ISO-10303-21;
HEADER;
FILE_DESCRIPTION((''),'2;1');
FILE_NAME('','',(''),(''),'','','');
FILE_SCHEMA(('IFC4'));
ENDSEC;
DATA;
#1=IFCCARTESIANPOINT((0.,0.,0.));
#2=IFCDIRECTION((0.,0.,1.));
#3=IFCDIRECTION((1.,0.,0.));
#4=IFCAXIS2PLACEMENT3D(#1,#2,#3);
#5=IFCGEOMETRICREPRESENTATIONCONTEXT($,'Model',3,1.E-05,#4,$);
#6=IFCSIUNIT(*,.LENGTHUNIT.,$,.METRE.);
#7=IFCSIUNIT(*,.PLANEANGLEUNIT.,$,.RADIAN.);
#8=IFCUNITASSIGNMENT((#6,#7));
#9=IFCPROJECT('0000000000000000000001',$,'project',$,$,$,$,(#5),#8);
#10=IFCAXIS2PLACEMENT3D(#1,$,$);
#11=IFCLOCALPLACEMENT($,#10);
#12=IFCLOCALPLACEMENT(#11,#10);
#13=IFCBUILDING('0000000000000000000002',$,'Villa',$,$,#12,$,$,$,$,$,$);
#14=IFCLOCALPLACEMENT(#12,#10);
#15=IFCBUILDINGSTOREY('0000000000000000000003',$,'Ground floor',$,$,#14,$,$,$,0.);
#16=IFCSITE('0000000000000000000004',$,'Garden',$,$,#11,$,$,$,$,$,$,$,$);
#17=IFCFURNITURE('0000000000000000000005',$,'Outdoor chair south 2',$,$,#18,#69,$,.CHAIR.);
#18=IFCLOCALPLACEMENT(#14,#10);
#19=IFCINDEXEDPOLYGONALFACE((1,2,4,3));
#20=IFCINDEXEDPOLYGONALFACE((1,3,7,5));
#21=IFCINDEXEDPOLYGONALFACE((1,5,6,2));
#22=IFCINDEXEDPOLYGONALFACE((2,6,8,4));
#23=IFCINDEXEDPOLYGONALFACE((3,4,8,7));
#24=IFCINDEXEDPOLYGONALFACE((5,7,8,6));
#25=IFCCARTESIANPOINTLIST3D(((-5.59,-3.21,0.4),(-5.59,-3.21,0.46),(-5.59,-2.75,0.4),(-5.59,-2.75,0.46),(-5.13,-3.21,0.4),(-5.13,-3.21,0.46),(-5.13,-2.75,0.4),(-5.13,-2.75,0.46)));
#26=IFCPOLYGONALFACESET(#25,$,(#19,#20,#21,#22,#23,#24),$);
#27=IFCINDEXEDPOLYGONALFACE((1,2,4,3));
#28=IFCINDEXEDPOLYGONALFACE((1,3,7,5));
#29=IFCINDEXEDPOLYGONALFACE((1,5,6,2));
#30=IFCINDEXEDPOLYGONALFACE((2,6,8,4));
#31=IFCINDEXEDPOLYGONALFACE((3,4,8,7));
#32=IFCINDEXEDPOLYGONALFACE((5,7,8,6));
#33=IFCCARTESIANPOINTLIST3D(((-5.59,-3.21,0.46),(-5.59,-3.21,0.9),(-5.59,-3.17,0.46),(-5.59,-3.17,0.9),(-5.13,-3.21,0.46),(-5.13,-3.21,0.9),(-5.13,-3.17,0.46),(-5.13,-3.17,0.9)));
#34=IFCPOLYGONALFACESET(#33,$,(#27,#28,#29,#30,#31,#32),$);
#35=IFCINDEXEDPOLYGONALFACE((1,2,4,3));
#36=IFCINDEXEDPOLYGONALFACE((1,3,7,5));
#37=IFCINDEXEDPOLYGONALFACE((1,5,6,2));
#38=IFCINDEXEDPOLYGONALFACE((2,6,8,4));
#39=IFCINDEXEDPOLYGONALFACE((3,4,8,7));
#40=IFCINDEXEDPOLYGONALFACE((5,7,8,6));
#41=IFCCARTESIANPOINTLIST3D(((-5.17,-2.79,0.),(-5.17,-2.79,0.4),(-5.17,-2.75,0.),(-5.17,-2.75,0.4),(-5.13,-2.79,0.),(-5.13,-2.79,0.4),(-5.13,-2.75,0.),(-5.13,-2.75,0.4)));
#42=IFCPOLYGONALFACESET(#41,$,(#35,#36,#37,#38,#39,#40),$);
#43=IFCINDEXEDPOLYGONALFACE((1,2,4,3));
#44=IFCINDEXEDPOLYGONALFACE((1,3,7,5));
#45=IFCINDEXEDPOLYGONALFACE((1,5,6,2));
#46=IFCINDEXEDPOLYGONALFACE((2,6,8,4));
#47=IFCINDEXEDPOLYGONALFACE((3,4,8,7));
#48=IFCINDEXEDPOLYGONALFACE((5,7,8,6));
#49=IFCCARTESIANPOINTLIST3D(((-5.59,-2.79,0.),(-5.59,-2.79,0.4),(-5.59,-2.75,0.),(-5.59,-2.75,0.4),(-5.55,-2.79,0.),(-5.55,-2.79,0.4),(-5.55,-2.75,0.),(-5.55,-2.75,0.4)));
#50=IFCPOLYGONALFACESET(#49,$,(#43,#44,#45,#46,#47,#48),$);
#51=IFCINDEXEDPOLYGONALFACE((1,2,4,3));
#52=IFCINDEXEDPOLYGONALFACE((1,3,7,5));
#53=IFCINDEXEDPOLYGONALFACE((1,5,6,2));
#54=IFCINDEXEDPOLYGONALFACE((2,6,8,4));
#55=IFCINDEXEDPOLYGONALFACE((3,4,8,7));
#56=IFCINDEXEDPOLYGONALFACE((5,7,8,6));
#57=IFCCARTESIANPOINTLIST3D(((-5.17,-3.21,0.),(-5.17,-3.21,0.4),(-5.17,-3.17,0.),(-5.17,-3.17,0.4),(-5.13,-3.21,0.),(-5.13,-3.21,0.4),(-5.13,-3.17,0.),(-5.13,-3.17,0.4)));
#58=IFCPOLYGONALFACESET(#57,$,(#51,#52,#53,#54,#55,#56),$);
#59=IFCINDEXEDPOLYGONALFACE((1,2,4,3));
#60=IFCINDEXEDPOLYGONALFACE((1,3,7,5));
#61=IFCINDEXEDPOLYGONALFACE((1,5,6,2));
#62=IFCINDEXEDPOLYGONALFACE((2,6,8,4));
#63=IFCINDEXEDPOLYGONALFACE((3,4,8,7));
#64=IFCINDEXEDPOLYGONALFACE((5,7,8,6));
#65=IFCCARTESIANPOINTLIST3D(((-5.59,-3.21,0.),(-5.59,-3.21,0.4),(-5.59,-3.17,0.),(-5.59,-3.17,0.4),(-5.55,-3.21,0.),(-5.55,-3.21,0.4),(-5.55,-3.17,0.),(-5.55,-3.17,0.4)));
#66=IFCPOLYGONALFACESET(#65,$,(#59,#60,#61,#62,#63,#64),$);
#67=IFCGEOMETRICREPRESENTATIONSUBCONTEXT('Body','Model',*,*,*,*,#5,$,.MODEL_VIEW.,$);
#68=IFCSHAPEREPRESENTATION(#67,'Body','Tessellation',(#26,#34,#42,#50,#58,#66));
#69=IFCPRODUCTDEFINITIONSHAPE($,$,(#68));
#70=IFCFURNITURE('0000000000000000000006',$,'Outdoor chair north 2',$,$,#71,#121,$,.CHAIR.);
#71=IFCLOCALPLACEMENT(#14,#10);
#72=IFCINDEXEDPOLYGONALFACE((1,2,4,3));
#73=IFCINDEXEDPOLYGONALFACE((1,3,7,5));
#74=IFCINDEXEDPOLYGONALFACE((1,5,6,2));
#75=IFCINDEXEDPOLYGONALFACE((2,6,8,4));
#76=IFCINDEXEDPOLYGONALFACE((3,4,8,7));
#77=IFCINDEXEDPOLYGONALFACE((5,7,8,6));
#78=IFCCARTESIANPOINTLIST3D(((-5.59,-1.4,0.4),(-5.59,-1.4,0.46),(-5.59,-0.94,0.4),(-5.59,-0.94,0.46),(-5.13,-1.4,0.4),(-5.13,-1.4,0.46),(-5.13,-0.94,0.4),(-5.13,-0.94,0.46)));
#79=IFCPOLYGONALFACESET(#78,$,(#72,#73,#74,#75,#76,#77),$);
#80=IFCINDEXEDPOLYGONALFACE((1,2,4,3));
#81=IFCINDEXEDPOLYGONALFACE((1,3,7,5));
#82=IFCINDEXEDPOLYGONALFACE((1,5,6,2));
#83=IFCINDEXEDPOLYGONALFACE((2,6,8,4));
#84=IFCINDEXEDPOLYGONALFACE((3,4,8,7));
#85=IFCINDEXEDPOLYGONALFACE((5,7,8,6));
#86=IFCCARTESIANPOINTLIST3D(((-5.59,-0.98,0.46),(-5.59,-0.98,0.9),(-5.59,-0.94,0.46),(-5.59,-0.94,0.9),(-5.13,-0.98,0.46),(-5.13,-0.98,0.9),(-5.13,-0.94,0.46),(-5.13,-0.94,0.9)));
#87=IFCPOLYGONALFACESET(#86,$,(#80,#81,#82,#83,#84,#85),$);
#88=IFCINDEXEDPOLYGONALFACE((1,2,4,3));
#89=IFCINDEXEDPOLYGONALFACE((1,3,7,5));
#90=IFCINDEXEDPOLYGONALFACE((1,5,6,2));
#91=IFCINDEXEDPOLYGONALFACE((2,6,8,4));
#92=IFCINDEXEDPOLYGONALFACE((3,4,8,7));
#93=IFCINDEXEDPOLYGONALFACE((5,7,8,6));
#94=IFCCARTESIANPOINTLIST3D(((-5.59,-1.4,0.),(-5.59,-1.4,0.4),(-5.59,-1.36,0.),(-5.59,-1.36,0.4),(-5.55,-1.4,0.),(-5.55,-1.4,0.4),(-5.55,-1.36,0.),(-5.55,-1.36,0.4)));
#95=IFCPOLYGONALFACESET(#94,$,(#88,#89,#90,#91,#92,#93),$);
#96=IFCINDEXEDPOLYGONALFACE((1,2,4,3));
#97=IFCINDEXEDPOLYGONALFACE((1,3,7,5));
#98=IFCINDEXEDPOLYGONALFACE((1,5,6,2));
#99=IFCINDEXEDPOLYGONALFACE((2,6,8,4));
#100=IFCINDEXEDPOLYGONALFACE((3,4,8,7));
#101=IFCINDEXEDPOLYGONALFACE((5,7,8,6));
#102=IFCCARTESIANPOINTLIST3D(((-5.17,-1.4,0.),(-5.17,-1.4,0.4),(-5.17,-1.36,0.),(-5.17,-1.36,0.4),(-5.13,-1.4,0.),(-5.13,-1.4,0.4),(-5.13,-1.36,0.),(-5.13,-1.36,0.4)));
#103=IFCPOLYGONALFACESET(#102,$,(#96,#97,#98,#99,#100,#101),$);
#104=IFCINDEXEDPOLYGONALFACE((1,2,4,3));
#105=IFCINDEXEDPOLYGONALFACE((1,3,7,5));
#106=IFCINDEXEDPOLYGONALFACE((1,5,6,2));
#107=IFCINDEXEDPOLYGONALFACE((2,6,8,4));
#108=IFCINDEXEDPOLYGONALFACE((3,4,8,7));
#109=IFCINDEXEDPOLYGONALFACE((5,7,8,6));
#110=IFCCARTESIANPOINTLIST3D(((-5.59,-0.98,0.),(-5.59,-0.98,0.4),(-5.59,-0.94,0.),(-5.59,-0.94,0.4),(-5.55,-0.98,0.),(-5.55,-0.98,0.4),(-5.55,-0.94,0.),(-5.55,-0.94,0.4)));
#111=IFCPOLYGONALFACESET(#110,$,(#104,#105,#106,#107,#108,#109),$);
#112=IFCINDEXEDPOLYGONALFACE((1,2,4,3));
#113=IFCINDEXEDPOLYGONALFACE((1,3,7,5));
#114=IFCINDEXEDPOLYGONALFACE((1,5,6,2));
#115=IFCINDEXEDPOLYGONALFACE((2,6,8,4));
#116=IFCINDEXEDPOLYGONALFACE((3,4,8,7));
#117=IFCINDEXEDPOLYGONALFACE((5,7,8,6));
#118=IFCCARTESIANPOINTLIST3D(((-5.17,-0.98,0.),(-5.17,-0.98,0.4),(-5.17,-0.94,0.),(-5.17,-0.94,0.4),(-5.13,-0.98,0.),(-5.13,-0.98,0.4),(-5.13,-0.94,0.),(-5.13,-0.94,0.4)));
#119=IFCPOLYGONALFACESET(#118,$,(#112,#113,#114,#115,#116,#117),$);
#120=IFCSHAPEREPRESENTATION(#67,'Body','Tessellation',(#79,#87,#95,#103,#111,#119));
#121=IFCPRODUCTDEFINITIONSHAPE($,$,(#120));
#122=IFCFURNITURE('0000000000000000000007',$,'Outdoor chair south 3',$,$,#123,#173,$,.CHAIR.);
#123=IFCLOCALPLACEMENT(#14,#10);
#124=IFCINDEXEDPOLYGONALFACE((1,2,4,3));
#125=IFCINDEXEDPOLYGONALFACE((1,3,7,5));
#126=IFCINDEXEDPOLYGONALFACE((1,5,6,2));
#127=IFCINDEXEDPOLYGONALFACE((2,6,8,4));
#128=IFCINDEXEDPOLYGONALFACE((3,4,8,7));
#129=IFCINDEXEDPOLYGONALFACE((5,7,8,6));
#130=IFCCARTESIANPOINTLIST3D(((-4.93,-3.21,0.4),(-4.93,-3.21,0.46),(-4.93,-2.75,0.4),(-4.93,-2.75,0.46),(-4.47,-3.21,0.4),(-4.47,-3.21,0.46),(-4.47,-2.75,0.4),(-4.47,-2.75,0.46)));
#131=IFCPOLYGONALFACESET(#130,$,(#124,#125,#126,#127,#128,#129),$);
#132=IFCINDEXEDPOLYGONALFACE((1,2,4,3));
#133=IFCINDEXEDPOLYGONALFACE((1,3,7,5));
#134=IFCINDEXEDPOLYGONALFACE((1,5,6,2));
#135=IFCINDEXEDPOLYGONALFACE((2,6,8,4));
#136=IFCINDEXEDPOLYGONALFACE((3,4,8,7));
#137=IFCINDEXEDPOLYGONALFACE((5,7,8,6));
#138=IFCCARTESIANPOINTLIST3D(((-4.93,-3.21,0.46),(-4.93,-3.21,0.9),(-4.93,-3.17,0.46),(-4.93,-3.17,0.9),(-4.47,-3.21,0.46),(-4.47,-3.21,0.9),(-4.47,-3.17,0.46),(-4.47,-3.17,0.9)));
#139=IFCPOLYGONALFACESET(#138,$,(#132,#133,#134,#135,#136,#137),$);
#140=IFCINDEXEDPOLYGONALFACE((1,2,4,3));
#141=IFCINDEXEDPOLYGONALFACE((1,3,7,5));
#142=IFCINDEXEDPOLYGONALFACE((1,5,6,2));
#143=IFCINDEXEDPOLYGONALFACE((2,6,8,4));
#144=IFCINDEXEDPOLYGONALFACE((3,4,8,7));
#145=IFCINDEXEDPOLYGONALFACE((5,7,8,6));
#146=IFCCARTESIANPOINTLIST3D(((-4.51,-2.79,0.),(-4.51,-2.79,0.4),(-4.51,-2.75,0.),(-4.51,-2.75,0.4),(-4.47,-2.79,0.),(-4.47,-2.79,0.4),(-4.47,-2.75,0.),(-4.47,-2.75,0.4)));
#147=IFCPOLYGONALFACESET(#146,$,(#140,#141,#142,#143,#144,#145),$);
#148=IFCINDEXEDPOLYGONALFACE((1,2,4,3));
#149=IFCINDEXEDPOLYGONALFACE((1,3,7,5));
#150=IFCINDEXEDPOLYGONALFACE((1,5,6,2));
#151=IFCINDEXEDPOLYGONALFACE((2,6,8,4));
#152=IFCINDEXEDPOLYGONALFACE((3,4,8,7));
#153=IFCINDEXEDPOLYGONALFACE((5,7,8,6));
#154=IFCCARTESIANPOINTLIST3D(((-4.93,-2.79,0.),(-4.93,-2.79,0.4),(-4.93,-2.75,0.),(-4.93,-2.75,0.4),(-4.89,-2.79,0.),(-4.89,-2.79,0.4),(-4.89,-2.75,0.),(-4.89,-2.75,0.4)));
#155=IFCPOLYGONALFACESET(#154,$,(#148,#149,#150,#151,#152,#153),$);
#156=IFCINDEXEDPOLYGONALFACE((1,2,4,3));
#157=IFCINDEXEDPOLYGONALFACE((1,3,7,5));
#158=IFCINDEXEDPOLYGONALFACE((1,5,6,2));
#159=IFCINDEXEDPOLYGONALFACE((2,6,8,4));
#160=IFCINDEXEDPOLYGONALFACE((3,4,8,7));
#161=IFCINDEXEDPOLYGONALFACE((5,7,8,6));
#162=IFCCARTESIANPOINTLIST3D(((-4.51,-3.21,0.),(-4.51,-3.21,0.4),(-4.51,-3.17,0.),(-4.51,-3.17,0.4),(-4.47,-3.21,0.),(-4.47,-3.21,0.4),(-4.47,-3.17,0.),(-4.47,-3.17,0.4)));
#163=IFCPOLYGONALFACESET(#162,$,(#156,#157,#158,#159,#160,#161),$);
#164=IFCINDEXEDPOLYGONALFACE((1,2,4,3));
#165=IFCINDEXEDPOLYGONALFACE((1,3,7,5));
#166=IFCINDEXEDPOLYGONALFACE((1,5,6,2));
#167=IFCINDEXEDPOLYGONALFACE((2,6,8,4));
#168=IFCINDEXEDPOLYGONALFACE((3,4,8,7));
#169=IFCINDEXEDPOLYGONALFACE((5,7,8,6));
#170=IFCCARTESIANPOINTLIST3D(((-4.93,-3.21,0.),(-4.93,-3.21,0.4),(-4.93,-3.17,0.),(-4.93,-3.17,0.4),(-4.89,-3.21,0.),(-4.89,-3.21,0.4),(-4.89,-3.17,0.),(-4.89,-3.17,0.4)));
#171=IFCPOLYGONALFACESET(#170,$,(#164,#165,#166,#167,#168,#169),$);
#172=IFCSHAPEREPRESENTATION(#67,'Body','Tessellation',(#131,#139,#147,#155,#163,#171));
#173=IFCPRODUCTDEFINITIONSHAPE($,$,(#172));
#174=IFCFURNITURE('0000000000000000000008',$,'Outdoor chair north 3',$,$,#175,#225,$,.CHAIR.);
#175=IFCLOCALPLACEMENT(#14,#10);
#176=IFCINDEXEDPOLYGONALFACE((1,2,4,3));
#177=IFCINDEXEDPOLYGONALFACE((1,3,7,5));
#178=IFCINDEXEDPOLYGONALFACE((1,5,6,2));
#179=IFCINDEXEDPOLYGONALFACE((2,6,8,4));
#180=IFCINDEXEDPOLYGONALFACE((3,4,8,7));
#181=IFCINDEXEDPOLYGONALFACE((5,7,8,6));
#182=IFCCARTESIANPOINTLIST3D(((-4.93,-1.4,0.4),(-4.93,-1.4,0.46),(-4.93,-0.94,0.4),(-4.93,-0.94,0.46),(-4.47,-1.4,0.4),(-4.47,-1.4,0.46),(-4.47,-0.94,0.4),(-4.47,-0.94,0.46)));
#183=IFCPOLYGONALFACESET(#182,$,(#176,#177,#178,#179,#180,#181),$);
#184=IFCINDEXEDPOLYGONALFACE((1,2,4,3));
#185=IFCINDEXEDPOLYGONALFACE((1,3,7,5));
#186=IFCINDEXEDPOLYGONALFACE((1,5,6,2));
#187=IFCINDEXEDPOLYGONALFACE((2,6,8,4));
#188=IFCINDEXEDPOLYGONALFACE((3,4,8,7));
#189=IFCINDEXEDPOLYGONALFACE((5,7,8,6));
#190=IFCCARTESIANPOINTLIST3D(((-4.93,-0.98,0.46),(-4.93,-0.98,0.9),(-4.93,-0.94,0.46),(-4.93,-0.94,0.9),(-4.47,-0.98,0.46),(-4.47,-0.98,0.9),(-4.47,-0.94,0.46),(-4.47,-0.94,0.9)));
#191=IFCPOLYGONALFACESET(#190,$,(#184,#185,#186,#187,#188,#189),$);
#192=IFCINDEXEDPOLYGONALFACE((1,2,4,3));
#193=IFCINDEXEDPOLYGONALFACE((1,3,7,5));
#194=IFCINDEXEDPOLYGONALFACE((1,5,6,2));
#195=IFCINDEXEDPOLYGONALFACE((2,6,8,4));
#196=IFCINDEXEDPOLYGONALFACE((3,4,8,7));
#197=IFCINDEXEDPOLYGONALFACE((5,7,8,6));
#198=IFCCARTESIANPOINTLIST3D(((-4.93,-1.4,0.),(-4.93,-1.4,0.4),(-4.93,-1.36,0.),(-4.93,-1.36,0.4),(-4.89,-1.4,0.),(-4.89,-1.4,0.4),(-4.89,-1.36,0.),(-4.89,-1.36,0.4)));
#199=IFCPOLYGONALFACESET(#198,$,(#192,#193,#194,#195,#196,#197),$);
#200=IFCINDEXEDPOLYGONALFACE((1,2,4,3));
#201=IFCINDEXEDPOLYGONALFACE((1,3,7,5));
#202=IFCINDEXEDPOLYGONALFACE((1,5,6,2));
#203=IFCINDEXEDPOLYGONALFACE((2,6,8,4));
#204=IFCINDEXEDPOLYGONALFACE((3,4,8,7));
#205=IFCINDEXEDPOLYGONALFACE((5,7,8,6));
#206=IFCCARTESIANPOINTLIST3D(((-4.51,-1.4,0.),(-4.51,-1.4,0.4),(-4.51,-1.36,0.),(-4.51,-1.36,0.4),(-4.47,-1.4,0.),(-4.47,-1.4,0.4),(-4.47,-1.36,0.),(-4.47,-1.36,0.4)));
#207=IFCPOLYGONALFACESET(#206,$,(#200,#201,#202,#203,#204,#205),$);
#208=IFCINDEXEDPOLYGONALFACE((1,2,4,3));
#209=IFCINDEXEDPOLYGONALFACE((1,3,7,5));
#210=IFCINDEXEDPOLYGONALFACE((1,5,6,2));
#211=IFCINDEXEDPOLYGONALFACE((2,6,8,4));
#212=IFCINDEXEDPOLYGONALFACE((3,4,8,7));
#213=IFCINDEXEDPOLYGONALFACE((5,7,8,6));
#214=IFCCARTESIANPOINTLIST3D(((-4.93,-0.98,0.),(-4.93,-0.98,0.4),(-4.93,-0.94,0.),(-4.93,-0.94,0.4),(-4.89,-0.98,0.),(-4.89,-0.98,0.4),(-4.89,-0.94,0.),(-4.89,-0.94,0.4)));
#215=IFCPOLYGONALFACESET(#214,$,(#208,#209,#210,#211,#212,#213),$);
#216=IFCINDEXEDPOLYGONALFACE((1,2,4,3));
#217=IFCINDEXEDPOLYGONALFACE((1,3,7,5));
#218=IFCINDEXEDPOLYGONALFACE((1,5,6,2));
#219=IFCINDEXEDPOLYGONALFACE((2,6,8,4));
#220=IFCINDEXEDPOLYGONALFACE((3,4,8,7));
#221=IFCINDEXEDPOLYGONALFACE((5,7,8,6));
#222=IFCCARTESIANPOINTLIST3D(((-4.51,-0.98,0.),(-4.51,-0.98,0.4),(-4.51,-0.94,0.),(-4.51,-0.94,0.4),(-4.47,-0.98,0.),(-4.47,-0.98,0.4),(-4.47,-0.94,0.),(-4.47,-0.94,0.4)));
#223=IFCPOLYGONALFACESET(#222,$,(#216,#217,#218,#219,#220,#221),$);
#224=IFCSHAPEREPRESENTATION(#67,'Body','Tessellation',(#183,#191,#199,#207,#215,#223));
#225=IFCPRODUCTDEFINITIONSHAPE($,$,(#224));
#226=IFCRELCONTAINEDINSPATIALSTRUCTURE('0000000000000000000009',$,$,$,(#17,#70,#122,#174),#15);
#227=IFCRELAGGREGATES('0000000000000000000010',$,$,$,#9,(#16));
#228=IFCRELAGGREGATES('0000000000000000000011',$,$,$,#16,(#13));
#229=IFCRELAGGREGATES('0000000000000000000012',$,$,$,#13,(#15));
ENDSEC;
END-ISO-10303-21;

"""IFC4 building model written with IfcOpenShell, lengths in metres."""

from ifc_helpers import new_model, si_unit, frame, frame_2d, origin, origin_with_axes, place, context, subcontext, project, spatial, rectangle, extrude, element, save


model = new_model("IFC4")

# Units and contexts
model_context = context("Model", 3, precision=1e-05, world=origin_with_axes())
body_context = subcontext(model_context, "Body", "Model", "MODEL_VIEW")
ifc_project = project(units=[si_unit("LENGTHUNIT", "METRE"), si_unit("PLANEANGLEUNIT", "RADIAN")], contexts=[model_context])

# Site, building, storey
site_placement = place(None, origin())
site = spatial("IfcSite", under=ifc_project, at=site_placement, Name="Garden")
building_placement = place(site_placement, origin())
building = spatial("IfcBuilding", under=site, at=building_placement, Name="Villa")
storey_placement = place(building_placement, origin())
storey = spatial("IfcBuildingStorey", under=building, at=storey_placement, Name="Ground floor", Elevation=0.0)

# Furniture
furniture_1_placement = place(storey_placement, frame((-5.13, -2.75, 0.0), x_axis=(-1.0, 0.0, 0.0)))
element("IfcFurniture", 1, at=furniture_1_placement, inside=storey, Name="Outdoor chair south 2", PredefinedType="CHAIR", context=body_context, shape_type="SweptSolid", body=[
    extrude(rectangle(XDim=0.46, YDim=0.46, at=frame_2d((0.23, 0.23))), frame((0.0, 0.0, 0.4)), (0.0, 0.0, 1.0), 0.06),
    extrude(rectangle(XDim=0.46, YDim=0.04, at=frame_2d((0.23, 0.02))), frame((0.0, 0.42, 0.46)), (0.0, 0.0, 1.0), 0.44),
    extrude(rectangle(XDim=0.04, YDim=0.04, at=frame_2d((0.02, 0.02))), origin(), (0.0, 0.0, 1.0), 0.4),
    extrude(rectangle(XDim=0.04, YDim=0.04, at=frame_2d((0.02, 0.02))), frame((0.42, 0.0, 0.0)), (0.0, 0.0, 1.0), 0.4),
    extrude(rectangle(XDim=0.04, YDim=0.04, at=frame_2d((0.02, 0.02))), frame((0.0, 0.42, 0.0)), (0.0, 0.0, 1.0), 0.4),
    extrude(rectangle(XDim=0.04, YDim=0.04, at=frame_2d((0.02, 0.02))), frame((0.42, 0.42, 0.0)), (0.0, 0.0, 1.0), 0.4),
])
furniture_2_placement = place(storey_placement, frame((-5.59, -1.4, 0.0)))
element("IfcFurniture", 2, at=furniture_2_placement, inside=storey, Name="Outdoor chair north 2", PredefinedType="CHAIR", context=body_context, shape_type="SweptSolid", body=[
    extrude(rectangle(XDim=0.46, YDim=0.46, at=frame_2d((0.23, 0.23))), frame((0.0, 0.0, 0.4)), (0.0, 0.0, 1.0), 0.06),
    extrude(rectangle(XDim=0.46, YDim=0.04, at=frame_2d((0.23, 0.02))), frame((0.0, 0.42, 0.46)), (0.0, 0.0, 1.0), 0.44),
    extrude(rectangle(XDim=0.04, YDim=0.04, at=frame_2d((0.02, 0.02))), origin(), (0.0, 0.0, 1.0), 0.4),
    extrude(rectangle(XDim=0.04, YDim=0.04, at=frame_2d((0.02, 0.02))), frame((0.42, 0.0, 0.0)), (0.0, 0.0, 1.0), 0.4),
    extrude(rectangle(XDim=0.04, YDim=0.04, at=frame_2d((0.02, 0.02))), frame((0.0, 0.42, 0.0)), (0.0, 0.0, 1.0), 0.4),
    extrude(rectangle(XDim=0.04, YDim=0.04, at=frame_2d((0.02, 0.02))), frame((0.42, 0.42, 0.0)), (0.0, 0.0, 1.0), 0.4),
])
furniture_3_placement = place(storey_placement, frame((-4.47, -2.75, 0.0), x_axis=(-1.0, 0.0, 0.0)))
element("IfcFurniture", 3, at=furniture_3_placement, inside=storey, Name="Outdoor chair south 3", PredefinedType="CHAIR", context=body_context, shape_type="SweptSolid", body=[
    extrude(rectangle(XDim=0.46, YDim=0.46, at=frame_2d((0.23, 0.23))), frame((0.0, 0.0, 0.4)), (0.0, 0.0, 1.0), 0.06),
    extrude(rectangle(XDim=0.46, YDim=0.04, at=frame_2d((0.23, 0.02))), frame((0.0, 0.42, 0.46)), (0.0, 0.0, 1.0), 0.44),
    extrude(rectangle(XDim=0.04, YDim=0.04, at=frame_2d((0.02, 0.02))), origin(), (0.0, 0.0, 1.0), 0.4),
    extrude(rectangle(XDim=0.04, YDim=0.04, at=frame_2d((0.02, 0.02))), frame((0.42, 0.0, 0.0)), (0.0, 0.0, 1.0), 0.4),
    extrude(rectangle(XDim=0.04, YDim=0.04, at=frame_2d((0.02, 0.02))), frame((0.0, 0.42, 0.0)), (0.0, 0.0, 1.0), 0.4),
    extrude(rectangle(XDim=0.04, YDim=0.04, at=frame_2d((0.02, 0.02))), frame((0.42, 0.42, 0.0)), (0.0, 0.0, 1.0), 0.4),
])
furniture_4_placement = place(storey_placement, frame((-4.93, -1.4, 0.0)))
element("IfcFurniture", 4, at=furniture_4_placement, inside=storey, Name="Outdoor chair north 3", PredefinedType="CHAIR", context=body_context, shape_type="SweptSolid", body=[
    extrude(rectangle(XDim=0.46, YDim=0.46, at=frame_2d((0.23, 0.23))), frame((0.0, 0.0, 0.4)), (0.0, 0.0, 1.0), 0.06),
    extrude(rectangle(XDim=0.46, YDim=0.04, at=frame_2d((0.23, 0.02))), frame((0.0, 0.42, 0.46)), (0.0, 0.0, 1.0), 0.44),
    extrude(rectangle(XDim=0.04, YDim=0.04, at=frame_2d((0.02, 0.02))), origin(), (0.0, 0.0, 1.0), 0.4),
    extrude(rectangle(XDim=0.04, YDim=0.04, at=frame_2d((0.02, 0.02))), frame((0.42, 0.0, 0.0)), (0.0, 0.0, 1.0), 0.4),
    extrude(rectangle(XDim=0.04, YDim=0.04, at=frame_2d((0.02, 0.02))), frame((0.0, 0.42, 0.0)), (0.0, 0.0, 1.0), 0.4),
    extrude(rectangle(XDim=0.04, YDim=0.04, at=frame_2d((0.02, 0.02))), frame((0.42, 0.42, 0.0)), (0.0, 0.0, 1.0), 0.4),
])

save(model, "model.ifc")
